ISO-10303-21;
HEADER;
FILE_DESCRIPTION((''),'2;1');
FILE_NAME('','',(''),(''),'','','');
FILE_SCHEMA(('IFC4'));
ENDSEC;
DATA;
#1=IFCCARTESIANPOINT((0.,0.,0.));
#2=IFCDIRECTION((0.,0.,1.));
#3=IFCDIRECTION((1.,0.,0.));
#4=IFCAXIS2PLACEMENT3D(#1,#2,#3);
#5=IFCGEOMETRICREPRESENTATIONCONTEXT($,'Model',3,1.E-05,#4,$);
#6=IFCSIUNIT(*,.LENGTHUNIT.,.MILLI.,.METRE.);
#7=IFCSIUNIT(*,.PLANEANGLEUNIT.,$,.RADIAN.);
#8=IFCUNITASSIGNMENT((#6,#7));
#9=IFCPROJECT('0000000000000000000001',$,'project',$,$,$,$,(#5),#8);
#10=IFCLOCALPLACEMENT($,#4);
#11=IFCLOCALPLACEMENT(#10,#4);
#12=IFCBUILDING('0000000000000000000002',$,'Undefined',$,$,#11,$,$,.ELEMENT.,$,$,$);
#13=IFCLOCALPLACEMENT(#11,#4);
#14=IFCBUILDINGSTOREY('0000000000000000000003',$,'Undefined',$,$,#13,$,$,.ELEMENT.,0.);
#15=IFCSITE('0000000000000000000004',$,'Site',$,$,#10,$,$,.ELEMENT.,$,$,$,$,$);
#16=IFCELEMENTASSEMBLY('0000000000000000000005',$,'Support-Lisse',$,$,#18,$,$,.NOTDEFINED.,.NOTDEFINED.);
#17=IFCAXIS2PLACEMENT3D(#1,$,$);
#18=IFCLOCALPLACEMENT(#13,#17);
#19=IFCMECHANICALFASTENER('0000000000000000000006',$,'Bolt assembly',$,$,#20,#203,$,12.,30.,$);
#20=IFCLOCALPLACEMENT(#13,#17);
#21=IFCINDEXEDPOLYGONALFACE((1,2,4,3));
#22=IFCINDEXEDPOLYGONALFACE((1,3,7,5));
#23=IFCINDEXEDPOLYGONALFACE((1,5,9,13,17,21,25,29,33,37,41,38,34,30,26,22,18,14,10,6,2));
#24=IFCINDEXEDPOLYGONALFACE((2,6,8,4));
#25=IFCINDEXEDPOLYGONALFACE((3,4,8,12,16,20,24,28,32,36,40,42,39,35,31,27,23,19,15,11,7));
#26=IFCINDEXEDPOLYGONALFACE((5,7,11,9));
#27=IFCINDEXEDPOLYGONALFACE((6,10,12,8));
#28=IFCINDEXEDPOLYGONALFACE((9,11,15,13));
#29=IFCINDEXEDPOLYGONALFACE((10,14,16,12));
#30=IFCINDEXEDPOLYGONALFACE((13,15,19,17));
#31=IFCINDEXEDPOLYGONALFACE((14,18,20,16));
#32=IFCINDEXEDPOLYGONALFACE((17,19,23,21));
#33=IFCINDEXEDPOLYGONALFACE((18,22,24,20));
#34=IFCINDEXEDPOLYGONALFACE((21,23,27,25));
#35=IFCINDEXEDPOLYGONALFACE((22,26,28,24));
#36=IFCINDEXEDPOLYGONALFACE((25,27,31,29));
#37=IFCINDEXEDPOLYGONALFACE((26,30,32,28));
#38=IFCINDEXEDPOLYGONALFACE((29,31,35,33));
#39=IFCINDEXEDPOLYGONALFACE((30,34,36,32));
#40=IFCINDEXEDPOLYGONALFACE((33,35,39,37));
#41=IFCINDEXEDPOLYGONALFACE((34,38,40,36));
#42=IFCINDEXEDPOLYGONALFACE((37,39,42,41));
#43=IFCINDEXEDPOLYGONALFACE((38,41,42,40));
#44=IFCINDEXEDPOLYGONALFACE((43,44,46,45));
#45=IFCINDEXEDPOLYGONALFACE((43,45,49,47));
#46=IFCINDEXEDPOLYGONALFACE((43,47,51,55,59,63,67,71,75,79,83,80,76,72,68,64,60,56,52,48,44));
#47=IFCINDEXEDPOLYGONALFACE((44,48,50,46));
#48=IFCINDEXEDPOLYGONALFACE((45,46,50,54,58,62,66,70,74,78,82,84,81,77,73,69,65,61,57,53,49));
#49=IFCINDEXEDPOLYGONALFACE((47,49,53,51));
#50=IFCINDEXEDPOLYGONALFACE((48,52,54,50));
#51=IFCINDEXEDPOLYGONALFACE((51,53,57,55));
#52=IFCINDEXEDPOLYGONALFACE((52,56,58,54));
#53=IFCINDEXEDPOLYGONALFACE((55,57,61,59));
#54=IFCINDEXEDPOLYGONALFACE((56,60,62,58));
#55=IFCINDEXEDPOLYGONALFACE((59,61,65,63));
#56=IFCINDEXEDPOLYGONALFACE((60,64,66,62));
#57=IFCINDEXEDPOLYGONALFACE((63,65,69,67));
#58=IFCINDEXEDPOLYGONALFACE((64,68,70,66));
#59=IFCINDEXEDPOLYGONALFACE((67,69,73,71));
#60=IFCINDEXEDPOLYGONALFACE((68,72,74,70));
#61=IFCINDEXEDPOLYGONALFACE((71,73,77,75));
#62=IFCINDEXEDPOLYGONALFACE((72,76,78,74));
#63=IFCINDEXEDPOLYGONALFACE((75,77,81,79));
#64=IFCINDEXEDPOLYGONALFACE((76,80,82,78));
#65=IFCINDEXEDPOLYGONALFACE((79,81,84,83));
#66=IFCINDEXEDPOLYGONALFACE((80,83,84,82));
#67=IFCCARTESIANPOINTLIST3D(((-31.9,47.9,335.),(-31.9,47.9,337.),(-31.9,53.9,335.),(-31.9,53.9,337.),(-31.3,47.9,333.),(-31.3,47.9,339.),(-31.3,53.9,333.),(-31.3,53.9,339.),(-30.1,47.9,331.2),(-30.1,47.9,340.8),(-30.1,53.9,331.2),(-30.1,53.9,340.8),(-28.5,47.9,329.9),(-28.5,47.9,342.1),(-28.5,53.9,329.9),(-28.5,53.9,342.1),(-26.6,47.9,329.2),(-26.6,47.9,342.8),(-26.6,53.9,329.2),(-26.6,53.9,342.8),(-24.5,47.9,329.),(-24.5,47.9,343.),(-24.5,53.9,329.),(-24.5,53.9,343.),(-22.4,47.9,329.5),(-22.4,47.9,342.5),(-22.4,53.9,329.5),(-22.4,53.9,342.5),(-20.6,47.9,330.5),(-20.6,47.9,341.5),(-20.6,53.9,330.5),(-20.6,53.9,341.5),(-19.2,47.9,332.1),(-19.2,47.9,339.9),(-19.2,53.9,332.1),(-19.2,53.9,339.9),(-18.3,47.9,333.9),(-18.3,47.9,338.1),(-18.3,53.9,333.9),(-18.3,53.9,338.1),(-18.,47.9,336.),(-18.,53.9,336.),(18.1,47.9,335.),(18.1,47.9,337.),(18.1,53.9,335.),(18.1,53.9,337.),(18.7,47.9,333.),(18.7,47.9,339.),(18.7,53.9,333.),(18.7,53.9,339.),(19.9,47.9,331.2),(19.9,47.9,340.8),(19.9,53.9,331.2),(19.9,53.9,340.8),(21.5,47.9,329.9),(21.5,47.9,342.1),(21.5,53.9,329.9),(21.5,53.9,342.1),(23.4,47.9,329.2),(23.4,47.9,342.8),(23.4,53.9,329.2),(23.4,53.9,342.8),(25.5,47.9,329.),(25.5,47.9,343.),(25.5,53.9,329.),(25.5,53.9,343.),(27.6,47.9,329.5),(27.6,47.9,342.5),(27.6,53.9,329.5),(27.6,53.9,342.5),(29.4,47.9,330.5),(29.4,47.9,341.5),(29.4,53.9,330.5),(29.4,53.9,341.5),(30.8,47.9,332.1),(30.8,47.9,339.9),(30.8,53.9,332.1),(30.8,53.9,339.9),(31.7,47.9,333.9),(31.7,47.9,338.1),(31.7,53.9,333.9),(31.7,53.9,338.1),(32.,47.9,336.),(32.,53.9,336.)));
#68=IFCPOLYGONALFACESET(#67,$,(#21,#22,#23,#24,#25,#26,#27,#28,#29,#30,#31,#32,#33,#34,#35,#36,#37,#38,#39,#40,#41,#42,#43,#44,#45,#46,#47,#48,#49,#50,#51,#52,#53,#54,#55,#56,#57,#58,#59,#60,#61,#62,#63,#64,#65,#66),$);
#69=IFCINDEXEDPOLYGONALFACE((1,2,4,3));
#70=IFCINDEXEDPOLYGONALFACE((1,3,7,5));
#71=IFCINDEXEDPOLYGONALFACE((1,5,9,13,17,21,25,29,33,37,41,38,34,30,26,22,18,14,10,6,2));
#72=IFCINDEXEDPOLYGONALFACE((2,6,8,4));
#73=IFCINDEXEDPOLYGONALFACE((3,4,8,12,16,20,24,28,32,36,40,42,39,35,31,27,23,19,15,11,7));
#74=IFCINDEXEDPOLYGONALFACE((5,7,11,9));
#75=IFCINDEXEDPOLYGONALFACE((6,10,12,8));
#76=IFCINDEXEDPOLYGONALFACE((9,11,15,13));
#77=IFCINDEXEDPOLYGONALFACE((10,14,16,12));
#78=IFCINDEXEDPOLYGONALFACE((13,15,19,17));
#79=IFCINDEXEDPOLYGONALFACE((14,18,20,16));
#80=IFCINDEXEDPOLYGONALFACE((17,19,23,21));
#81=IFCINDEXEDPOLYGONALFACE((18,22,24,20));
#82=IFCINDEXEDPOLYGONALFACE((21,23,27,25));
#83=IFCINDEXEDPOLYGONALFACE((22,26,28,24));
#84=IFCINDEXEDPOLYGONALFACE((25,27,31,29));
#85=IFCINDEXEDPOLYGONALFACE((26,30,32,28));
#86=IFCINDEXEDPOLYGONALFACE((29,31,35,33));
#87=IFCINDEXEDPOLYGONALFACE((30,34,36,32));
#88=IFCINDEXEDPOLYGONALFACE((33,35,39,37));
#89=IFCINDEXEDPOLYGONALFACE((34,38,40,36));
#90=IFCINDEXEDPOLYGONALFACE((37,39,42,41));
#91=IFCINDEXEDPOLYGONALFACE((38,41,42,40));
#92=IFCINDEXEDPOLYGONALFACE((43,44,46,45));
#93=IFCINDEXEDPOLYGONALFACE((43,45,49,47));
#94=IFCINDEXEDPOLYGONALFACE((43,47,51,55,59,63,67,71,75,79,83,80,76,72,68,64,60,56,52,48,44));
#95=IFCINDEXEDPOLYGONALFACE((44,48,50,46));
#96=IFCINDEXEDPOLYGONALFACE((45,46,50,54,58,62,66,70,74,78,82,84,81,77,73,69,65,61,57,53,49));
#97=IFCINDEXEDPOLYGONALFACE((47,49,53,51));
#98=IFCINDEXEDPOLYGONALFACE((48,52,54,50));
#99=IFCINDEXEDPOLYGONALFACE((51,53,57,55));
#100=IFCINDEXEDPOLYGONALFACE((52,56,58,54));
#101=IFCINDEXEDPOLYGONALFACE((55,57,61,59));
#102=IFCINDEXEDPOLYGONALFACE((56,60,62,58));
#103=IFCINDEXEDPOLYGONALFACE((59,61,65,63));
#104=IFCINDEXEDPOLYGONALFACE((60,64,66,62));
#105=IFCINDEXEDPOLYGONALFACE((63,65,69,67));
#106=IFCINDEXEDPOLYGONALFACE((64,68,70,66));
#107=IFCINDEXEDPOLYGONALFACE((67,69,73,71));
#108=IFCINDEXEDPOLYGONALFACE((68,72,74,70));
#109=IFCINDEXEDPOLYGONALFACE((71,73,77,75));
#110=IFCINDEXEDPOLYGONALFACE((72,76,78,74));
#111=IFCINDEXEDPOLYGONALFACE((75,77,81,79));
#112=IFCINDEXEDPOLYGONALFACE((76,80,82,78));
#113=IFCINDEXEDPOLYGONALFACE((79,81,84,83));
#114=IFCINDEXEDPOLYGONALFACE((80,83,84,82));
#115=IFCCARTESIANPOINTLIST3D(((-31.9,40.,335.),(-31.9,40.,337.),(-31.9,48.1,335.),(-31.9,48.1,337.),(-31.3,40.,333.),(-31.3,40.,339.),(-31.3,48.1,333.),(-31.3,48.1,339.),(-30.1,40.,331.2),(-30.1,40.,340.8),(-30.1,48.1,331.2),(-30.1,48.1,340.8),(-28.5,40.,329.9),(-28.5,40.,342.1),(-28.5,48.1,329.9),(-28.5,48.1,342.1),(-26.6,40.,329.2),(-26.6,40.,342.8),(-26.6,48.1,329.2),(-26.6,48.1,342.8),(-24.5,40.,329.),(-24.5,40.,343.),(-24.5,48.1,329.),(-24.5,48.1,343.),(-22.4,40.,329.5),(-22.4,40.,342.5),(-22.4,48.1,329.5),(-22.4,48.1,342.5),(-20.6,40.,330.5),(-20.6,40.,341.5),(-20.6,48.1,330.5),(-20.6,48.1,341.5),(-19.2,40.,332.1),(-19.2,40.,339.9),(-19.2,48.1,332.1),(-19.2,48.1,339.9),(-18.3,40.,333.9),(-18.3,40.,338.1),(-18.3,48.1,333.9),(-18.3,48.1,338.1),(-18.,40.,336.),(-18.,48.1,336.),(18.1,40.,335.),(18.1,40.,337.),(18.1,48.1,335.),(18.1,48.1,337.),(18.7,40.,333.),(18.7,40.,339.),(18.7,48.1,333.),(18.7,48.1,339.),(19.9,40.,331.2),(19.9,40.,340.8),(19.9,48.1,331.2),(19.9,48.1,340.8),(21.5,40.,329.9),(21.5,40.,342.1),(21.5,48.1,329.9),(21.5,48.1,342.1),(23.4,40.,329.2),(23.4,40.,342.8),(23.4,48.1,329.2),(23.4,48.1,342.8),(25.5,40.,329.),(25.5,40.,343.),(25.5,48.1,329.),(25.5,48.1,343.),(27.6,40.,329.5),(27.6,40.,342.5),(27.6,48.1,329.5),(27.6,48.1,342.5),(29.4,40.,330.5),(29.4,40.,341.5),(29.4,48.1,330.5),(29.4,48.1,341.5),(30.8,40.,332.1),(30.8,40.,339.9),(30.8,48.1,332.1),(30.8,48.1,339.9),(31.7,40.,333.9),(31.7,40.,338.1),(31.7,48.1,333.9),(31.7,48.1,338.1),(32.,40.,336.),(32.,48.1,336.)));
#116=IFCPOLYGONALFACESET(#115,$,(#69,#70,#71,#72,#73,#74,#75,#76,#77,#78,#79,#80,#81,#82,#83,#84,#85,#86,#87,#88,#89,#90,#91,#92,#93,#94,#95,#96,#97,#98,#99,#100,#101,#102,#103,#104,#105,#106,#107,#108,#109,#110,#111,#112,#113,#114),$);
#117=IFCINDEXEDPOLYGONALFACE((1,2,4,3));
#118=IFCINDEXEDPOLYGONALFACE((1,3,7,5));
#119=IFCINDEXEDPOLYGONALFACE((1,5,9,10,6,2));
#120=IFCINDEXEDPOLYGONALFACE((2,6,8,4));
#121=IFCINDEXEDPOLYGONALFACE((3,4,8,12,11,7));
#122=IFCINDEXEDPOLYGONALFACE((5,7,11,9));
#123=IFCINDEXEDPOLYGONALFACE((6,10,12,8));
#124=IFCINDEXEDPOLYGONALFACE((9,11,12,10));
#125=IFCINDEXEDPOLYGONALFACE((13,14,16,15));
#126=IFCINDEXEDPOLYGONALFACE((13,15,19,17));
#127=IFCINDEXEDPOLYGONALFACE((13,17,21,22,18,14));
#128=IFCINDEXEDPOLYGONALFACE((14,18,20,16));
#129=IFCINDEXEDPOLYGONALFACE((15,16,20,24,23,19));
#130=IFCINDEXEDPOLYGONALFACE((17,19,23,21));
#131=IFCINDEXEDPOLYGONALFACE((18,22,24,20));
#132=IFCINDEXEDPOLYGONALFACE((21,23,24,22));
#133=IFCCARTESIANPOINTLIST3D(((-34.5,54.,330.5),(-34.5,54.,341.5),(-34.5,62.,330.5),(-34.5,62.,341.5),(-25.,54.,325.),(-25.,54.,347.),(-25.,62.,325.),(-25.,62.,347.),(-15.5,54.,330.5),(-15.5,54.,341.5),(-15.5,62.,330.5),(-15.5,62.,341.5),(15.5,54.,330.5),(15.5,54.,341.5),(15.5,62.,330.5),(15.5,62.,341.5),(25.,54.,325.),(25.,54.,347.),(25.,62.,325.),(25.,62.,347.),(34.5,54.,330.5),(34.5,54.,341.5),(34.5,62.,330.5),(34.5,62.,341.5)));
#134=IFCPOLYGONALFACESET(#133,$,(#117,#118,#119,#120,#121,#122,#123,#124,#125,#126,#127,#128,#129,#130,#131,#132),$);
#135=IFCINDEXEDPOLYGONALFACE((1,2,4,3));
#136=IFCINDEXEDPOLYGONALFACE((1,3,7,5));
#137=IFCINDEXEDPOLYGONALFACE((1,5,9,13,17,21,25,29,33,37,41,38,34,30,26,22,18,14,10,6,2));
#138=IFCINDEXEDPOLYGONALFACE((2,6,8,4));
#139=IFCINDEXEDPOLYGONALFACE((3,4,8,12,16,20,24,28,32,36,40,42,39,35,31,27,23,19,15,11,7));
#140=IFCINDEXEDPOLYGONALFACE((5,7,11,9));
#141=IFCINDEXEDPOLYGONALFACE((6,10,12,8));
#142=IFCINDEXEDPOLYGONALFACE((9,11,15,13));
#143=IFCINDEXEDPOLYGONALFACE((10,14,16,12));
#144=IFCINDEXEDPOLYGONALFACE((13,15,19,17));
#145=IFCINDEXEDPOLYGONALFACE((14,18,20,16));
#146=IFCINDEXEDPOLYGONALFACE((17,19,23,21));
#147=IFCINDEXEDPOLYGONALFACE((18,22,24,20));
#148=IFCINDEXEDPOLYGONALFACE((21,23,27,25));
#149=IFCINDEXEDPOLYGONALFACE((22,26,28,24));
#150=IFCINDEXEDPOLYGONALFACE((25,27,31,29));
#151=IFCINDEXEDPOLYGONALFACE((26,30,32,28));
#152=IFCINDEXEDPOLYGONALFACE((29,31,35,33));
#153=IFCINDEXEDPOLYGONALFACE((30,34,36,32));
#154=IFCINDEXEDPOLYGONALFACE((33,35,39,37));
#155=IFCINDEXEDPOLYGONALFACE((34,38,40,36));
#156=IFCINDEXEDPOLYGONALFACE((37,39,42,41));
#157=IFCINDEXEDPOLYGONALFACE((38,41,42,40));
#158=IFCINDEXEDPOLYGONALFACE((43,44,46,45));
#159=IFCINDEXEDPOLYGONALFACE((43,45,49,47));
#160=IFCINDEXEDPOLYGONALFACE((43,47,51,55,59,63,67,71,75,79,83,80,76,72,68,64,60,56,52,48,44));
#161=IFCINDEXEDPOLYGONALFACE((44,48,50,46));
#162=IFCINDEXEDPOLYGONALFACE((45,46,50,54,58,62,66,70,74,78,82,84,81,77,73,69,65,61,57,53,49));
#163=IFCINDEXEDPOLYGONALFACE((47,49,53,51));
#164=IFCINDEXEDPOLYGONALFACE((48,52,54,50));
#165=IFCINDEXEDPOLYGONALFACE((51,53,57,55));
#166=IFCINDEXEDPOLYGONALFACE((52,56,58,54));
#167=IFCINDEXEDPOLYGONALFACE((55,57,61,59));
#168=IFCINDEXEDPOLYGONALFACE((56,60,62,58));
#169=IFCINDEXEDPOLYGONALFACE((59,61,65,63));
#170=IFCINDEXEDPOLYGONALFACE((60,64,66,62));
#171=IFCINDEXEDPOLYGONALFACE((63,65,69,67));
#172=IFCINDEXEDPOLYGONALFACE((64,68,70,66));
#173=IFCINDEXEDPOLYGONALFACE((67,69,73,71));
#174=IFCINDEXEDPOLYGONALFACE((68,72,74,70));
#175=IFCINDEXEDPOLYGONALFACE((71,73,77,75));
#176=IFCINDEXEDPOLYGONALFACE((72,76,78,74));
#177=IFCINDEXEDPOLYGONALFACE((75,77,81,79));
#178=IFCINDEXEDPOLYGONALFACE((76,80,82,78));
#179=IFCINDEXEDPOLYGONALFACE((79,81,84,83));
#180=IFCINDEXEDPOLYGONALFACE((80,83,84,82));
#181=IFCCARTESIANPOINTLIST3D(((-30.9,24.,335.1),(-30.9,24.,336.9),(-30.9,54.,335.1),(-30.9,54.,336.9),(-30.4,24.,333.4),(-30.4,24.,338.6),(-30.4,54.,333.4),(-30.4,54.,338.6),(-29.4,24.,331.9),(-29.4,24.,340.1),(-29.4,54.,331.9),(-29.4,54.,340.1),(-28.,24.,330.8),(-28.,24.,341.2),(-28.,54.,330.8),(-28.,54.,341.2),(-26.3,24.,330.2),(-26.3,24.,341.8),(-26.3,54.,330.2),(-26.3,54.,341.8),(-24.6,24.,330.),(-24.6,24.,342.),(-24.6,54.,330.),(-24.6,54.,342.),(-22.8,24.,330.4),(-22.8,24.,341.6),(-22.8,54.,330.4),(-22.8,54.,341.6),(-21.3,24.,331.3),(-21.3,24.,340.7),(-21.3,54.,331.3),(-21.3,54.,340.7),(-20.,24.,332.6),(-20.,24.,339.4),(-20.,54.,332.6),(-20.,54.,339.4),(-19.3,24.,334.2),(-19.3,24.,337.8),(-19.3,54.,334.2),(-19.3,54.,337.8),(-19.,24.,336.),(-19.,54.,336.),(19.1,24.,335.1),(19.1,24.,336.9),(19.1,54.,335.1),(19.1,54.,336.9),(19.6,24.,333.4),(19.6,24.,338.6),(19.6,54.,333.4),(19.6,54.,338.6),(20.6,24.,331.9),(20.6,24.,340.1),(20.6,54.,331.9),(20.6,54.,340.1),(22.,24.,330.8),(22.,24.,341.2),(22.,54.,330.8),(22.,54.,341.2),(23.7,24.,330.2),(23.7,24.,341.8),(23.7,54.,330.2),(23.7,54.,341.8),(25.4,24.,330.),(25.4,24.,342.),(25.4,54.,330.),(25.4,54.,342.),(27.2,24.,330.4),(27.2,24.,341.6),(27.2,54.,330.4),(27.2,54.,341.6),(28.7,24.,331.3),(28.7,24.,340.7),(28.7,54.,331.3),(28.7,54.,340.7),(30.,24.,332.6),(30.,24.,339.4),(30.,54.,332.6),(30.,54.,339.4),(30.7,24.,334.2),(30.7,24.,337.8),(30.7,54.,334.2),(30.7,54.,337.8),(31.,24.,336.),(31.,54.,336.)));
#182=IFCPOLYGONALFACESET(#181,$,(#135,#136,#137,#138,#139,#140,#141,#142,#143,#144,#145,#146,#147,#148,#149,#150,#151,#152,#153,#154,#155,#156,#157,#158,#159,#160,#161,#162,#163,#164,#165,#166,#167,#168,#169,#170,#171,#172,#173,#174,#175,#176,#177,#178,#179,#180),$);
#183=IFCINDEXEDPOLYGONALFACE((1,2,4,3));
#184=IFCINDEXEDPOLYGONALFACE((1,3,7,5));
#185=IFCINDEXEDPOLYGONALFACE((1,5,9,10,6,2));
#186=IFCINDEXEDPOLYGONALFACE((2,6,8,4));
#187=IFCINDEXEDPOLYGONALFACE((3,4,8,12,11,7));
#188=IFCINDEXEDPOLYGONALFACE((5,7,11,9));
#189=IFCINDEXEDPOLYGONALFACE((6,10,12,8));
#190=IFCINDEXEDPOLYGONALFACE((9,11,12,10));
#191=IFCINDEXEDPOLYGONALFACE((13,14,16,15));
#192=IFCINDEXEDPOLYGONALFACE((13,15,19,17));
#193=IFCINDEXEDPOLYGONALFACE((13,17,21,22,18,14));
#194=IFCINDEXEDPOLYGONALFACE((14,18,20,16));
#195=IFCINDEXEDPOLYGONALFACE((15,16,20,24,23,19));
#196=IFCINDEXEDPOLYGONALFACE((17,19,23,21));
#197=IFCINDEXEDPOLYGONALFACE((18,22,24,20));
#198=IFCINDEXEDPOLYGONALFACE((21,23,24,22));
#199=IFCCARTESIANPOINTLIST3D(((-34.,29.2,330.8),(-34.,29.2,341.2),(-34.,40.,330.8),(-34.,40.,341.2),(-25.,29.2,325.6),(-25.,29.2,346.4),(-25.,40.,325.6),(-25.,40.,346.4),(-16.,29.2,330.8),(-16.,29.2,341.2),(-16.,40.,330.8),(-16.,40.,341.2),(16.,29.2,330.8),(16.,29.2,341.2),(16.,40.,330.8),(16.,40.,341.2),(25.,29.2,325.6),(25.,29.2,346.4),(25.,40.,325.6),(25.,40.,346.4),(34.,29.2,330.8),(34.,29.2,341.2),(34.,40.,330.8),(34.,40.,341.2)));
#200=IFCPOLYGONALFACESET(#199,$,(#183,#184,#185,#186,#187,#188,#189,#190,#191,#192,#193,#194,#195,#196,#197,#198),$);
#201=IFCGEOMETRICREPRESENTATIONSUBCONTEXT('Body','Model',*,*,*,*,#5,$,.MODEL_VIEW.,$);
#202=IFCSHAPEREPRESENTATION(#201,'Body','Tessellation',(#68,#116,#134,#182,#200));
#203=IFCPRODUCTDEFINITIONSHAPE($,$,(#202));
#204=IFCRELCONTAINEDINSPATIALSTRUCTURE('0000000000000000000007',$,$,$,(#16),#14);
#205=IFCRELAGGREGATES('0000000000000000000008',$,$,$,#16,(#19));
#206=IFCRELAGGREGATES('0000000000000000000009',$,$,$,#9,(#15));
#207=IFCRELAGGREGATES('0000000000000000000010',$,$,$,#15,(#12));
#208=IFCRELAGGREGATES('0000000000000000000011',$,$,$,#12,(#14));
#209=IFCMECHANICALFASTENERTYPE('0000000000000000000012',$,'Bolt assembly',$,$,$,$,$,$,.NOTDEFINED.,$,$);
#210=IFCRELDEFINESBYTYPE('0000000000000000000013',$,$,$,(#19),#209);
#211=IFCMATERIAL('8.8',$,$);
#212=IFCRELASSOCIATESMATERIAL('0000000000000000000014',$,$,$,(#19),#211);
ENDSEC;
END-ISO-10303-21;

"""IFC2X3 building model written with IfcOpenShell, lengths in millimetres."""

from ifc_helpers import new_model, si_unit, frame, origin_with_axes, origin_2d_with_axis, place, context, subcontext, project, spatial, polyline, circle, outline, extrude, source, transform, mapped, material, type_object, element, aggregate, save


model = new_model("IFC2X3")

# Units and contexts
model_context = context("Model", 3, precision=1e-05, world=origin_with_axes())
body_context = subcontext(model_context, "Body", "Model", "MODEL_VIEW")
ifc_project = project(units=[si_unit("LENGTHUNIT", "METRE", prefix="MILLI"), si_unit("PLANEANGLEUNIT", "RADIAN")], contexts=[model_context])

# Site, building, storey
site_placement = place(None, origin_with_axes())
site = spatial("IfcSite", under=ifc_project, at=site_placement, Name="Site", CompositionType="ELEMENT")
building_placement = place(site_placement, origin_with_axes())
building = spatial("IfcBuilding", under=site, at=building_placement, Name="Undefined", CompositionType="ELEMENT")
storey_placement = place(building_placement, origin_with_axes())
storey = spatial("IfcBuildingStorey", under=building, at=storey_placement, Name="Undefined", CompositionType="ELEMENT", Elevation=0.0)

# Shared definitions
mechanical_fastener_type = type_object("IfcMechanicalFastenerType", Name="Bolt assembly")

# Shared definitions
ifc_material_1 = material(Name="8.8")

# Element assembly, mechanical fastener
assembly_1_placement = place(storey_placement, origin_with_axes())
assembly_1 = element("IfcElementAssembly", 1, at=assembly_1_placement, inside=storey, Name="Support-Lisse", AssemblyPlace="NOTDEFINED", PredefinedType="NOTDEFINED")
shared_shape_1 = source(origin_with_axes(), body_context, "Body", "SweptSolid", [
    extrude(circle(Radius=7.0, at=origin_2d_with_axis()), frame((0.0, -5.9, 0.0), z_axis=(0.0, 1.0, 0.0), x_axis=(1.0, 0.0, 0.0)), (0.0, 0.0, 1.0), 6.0),
    extrude(circle(Radius=7.0, at=origin_2d_with_axis()), frame((0.0, -0.1, 0.0), z_axis=(0.0, 1.0, 0.0), x_axis=(1.0, 0.0, 0.0)), (0.0, 0.0, 1.0), 8.1),
    extrude(outline(polyline([(9.5, -5.5), (9.5, 5.5), (0.0, 11.0), (-9.5, 5.5), (-9.5, -5.5), (0.0, -11.0), (9.5, -5.5)])), frame((0.0, -14.0, 0.0), z_axis=(0.0, 1.0, 0.0), x_axis=(1.0, 0.0, 0.0)), (0.0, 0.0, 1.0), 8.0),
    extrude(circle(Radius=6.0, at=origin_2d_with_axis()), frame((0.0, -6.0, 0.0), z_axis=(0.0, 1.0, 0.0), x_axis=(1.0, 0.0, 0.0)), (0.0, 0.0, 1.0), 30.0),
    extrude(outline(polyline([(9.0, -5.2), (9.0, 5.2), (0.0, 10.4), (-9.0, 5.2), (-9.0, -5.2), (0.0, -10.4), (9.0, -5.2)])), frame((0.0, 8.0, 0.0), z_axis=(0.0, 1.0, 0.0), x_axis=(1.0, 0.0, 0.0)), (0.0, 0.0, 1.0), 10.8),
])
mechanical_fastener_1_placement = place(assembly_1_placement, frame((-25.0, 48.0, 336.0), z_axis=(0.0, 0.0, -1.0), x_axis=(1.0, 0.0, 0.0)))
mechanical_fastener_1 = element("IfcMechanicalFastener", 2, at=mechanical_fastener_1_placement, type_object=mechanical_fastener_type, material=ifc_material_1, Name="Bolt assembly", NominalDiameter=12.0, NominalLength=30.0, context=body_context, shape_type="MappedRepresentation", body=[
    mapped(shared_shape_1, transform((0.0, 0.0, 0.0))),
    mapped(shared_shape_1, transform((50.0, 0.0, 0.0))),
])
aggregate(assembly_1, [mechanical_fastener_1])

save(model, "model.ifc")
